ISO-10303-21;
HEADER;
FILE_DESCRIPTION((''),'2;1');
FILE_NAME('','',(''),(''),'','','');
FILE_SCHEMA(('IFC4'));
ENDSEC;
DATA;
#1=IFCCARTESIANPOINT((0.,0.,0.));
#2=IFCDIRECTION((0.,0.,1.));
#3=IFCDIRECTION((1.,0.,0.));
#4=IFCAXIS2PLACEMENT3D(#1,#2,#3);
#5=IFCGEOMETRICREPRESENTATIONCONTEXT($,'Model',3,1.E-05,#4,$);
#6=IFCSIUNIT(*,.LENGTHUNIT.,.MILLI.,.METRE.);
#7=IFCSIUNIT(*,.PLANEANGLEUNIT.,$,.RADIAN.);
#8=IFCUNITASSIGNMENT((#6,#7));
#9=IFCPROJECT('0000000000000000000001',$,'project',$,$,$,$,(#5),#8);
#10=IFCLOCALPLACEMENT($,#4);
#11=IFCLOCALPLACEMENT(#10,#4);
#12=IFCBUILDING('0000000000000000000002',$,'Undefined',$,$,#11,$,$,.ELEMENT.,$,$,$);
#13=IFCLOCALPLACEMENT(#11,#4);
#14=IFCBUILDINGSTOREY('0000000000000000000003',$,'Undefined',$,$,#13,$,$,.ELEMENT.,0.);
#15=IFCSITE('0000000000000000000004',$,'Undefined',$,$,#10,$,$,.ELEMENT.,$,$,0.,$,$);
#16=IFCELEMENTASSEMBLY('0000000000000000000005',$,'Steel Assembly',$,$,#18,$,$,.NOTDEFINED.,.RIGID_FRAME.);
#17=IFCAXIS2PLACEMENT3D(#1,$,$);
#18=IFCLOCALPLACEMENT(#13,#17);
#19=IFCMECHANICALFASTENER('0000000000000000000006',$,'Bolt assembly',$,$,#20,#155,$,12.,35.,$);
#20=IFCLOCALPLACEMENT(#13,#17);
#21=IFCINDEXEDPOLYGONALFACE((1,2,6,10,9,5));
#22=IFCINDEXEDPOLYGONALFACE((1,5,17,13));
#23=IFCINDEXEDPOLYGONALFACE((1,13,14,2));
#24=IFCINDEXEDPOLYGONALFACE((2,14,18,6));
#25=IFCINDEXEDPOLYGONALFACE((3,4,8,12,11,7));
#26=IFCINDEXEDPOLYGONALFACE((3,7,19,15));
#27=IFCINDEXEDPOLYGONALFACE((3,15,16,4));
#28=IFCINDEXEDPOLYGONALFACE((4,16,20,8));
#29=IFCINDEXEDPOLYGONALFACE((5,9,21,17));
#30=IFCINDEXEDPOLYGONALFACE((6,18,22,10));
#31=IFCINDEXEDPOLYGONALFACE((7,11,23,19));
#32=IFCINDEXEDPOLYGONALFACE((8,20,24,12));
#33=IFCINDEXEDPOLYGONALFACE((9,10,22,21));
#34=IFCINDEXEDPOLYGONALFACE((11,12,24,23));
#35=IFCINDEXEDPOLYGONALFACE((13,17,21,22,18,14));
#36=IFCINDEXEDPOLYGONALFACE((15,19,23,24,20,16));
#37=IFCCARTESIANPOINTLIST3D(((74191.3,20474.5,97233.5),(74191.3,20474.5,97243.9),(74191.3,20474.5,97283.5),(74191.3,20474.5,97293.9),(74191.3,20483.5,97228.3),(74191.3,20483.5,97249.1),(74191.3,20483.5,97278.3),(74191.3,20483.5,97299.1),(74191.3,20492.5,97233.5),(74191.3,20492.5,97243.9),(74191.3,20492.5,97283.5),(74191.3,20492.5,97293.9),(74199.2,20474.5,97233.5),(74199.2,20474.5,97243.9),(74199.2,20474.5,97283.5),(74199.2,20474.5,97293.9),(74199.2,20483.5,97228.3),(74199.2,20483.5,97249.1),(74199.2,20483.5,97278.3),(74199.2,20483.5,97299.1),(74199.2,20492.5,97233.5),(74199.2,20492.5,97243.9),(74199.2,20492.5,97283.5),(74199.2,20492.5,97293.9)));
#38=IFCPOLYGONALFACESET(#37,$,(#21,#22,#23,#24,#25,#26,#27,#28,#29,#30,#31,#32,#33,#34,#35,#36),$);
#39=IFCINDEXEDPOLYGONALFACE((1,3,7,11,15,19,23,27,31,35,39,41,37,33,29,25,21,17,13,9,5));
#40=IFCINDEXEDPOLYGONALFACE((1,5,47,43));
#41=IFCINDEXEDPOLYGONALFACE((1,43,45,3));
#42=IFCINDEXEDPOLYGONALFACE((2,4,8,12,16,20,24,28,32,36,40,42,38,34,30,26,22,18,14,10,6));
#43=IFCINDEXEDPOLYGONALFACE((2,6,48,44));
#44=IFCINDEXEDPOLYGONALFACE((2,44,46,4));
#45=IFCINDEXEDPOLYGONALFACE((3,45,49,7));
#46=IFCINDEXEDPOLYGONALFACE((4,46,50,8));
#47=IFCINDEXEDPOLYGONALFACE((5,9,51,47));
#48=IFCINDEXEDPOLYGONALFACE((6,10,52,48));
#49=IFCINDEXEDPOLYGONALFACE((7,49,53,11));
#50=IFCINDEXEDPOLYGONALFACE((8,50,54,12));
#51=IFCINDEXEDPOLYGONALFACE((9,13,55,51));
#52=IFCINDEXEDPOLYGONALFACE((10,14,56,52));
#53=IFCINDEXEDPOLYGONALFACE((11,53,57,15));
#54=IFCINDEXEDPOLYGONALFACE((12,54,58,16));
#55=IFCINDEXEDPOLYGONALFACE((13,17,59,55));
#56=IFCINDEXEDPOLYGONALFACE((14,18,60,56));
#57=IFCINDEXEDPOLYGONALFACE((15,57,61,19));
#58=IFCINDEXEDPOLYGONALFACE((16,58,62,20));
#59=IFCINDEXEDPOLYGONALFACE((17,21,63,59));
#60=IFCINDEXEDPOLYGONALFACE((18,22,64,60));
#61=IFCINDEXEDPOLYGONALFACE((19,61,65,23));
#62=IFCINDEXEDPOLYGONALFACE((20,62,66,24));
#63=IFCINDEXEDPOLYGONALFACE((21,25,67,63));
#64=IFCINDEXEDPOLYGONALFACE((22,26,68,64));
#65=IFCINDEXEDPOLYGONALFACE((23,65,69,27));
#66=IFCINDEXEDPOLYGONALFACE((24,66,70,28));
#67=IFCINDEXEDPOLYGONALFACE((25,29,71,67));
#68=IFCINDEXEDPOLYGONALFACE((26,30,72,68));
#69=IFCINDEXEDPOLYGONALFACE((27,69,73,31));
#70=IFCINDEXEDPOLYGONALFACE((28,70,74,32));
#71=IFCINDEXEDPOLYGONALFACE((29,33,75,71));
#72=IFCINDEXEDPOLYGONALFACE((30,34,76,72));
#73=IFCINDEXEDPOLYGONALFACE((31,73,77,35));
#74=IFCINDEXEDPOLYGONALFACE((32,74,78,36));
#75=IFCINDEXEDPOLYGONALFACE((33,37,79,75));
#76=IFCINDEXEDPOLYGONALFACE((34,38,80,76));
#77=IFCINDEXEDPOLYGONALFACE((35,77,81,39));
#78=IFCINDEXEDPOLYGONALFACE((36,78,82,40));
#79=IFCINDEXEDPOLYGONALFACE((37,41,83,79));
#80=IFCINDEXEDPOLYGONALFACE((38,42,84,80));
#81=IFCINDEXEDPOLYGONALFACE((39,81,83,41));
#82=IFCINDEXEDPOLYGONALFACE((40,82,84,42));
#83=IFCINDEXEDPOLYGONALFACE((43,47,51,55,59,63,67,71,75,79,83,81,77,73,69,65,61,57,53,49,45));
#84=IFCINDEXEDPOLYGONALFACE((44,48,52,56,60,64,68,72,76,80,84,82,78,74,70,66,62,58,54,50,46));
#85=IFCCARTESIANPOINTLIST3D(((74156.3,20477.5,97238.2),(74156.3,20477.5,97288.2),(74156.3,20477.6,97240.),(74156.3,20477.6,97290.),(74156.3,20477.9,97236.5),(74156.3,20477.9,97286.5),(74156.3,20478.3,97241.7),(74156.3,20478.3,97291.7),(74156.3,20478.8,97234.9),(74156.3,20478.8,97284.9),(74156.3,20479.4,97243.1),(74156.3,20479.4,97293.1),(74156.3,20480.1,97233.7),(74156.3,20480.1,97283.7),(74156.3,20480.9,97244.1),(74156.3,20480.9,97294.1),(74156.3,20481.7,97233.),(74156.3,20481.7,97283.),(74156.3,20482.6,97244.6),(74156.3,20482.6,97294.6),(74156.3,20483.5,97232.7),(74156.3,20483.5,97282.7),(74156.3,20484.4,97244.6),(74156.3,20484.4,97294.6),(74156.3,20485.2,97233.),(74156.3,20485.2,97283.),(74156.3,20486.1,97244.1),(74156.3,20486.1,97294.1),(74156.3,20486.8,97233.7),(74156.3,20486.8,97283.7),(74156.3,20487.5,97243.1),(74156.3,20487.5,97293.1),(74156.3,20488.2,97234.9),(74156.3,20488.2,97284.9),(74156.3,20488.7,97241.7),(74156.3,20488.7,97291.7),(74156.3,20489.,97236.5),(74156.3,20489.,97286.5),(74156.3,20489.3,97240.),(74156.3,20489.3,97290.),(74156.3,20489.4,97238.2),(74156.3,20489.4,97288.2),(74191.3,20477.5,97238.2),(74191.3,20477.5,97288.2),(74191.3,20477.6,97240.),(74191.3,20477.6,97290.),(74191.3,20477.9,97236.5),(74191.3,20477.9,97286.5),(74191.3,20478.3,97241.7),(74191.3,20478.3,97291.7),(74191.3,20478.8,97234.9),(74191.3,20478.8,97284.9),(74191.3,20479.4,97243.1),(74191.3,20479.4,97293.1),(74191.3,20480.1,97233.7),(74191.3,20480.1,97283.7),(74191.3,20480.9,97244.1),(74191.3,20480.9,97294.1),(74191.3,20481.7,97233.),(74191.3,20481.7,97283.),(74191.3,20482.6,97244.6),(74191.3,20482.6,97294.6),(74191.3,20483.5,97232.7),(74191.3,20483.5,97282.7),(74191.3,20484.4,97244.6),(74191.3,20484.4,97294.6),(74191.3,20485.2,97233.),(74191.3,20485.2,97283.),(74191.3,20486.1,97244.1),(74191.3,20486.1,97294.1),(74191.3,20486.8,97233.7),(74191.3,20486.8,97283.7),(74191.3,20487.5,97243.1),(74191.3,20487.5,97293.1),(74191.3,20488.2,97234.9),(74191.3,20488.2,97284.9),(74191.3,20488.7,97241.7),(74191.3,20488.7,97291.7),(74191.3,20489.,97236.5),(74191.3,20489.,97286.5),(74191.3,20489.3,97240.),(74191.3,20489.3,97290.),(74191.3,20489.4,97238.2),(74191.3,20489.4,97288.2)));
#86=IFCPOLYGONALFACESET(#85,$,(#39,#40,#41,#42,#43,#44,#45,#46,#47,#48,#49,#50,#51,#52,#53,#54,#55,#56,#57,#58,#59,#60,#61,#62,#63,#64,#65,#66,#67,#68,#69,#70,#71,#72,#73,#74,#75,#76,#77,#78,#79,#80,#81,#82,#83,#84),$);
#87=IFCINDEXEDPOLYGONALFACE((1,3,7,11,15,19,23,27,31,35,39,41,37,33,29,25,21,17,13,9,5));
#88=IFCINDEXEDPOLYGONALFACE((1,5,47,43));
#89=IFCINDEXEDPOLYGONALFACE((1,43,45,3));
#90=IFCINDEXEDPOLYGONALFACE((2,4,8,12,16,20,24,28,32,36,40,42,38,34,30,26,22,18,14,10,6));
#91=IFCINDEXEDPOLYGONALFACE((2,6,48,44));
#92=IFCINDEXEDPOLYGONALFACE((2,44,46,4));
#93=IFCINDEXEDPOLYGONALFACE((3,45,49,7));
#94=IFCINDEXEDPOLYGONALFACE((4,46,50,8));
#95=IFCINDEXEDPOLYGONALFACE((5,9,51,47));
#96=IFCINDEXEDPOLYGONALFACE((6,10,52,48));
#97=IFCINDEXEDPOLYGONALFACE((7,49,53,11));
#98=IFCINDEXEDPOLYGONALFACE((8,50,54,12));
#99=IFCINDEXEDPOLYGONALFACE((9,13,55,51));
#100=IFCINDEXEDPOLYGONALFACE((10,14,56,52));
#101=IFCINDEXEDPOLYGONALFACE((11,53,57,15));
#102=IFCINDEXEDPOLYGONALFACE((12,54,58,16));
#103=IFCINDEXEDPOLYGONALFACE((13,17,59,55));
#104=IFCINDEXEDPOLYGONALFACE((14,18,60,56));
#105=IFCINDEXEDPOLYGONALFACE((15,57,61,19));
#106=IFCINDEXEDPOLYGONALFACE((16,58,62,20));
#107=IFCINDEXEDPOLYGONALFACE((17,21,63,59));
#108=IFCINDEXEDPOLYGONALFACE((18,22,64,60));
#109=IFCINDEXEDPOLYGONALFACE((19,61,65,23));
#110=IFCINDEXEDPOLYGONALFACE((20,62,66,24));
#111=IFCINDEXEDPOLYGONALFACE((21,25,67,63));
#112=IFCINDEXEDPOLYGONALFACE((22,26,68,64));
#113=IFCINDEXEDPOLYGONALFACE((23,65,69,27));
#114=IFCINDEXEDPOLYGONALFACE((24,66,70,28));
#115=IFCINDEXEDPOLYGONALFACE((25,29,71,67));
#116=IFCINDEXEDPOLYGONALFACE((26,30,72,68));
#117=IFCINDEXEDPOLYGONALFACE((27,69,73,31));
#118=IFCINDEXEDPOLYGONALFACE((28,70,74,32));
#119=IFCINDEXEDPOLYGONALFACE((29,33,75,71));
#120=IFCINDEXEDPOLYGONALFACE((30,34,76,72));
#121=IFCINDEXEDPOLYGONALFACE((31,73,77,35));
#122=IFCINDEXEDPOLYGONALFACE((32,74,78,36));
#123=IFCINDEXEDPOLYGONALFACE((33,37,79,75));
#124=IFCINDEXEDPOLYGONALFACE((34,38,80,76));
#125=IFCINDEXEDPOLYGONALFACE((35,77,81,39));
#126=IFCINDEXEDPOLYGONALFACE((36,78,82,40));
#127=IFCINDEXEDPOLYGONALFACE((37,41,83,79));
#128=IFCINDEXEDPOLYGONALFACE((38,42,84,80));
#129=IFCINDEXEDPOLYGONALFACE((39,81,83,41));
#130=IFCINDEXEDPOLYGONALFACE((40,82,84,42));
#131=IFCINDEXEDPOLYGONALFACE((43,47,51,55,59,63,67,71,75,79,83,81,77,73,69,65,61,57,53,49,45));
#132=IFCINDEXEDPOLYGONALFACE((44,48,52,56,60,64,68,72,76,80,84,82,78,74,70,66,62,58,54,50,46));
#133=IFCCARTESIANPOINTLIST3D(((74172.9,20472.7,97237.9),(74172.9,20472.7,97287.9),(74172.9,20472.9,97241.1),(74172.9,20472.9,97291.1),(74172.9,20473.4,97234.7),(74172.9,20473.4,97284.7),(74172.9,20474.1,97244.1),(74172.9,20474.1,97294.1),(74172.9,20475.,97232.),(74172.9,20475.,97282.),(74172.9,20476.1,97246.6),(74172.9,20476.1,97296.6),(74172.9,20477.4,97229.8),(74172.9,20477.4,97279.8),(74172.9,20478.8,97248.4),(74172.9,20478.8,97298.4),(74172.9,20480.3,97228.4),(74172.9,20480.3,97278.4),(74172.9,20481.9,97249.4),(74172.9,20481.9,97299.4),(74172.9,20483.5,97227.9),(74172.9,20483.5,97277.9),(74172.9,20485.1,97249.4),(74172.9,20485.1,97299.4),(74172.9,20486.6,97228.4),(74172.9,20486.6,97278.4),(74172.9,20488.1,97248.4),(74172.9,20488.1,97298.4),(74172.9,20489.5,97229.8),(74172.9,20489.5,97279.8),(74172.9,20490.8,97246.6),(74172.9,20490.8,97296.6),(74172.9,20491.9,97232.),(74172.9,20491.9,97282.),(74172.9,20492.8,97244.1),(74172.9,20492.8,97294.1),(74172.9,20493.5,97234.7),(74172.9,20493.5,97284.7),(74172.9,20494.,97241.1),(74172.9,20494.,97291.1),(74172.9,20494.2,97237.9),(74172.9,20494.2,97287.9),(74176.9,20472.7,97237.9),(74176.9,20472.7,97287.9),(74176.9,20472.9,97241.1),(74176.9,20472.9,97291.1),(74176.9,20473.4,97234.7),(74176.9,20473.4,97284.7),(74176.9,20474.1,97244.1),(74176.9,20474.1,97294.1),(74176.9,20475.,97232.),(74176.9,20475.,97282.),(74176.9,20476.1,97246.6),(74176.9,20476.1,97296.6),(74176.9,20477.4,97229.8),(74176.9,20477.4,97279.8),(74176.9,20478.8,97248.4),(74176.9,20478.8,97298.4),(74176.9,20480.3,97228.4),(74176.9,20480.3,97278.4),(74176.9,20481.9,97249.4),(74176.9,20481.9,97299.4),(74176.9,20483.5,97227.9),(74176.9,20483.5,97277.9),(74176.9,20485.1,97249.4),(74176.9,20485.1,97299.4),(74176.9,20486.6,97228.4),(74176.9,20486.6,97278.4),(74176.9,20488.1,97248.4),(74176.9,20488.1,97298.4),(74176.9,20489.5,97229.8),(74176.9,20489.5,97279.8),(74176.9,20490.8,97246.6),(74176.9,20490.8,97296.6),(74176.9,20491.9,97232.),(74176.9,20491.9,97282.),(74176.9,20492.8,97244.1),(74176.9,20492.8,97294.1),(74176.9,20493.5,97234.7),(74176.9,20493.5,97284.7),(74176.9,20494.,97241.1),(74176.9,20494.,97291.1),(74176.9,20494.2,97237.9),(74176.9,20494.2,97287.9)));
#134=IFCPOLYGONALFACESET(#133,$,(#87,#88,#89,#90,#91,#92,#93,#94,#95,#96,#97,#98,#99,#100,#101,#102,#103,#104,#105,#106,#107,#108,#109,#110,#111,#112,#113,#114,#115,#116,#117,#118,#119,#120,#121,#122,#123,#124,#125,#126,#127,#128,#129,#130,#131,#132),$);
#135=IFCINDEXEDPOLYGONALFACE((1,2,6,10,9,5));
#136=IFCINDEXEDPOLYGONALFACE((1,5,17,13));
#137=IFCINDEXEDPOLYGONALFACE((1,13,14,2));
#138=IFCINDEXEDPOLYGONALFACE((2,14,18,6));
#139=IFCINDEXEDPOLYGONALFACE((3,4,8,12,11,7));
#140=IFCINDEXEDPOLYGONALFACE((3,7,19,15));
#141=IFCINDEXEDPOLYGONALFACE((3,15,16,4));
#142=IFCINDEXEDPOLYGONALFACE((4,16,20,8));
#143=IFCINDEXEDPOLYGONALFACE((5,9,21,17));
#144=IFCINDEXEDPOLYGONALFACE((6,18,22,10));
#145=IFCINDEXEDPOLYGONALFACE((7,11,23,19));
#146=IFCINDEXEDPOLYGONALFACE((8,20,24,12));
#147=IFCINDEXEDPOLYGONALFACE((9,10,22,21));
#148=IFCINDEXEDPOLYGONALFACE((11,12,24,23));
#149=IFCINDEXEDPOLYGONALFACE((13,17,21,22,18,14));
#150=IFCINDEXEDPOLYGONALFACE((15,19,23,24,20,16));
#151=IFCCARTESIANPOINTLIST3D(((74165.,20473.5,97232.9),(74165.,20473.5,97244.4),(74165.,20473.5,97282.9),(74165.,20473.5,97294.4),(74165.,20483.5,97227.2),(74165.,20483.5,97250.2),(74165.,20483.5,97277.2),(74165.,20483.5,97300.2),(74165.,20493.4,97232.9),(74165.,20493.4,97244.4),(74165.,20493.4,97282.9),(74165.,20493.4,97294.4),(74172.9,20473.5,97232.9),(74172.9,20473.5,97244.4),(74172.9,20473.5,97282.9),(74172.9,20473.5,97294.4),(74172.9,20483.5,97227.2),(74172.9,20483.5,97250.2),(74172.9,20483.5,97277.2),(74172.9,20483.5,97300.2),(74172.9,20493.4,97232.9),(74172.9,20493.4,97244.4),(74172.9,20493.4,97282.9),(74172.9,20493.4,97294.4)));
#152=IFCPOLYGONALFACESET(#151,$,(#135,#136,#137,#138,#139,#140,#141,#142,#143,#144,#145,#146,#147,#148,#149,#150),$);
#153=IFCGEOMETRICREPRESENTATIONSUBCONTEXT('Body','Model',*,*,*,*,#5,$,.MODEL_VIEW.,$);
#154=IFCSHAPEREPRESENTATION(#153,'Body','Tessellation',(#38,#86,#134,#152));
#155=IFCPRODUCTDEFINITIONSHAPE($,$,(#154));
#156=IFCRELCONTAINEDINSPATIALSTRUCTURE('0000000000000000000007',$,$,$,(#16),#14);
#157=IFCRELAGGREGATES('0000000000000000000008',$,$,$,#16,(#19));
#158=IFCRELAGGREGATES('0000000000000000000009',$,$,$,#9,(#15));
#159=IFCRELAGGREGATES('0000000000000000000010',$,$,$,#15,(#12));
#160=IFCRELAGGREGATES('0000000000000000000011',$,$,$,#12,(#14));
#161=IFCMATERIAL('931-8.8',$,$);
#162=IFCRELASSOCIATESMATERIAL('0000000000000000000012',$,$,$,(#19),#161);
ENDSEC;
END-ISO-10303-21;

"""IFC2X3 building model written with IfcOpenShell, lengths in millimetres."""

from ifc_helpers import new_model, si_unit, frame, origin_with_axes, origin_2d_with_axis, place, context, subcontext, project, spatial, polyline, circle, outline, extrude, source, transform, mapped, material, element, aggregate, save


model = new_model("IFC2X3")

# Units and contexts
model_context = context("Model", 3, precision=1e-05, world=origin_with_axes())
body_context = subcontext(model_context, "Body", "Model", "MODEL_VIEW")
ifc_project = project(units=[si_unit("LENGTHUNIT", "METRE", prefix="MILLI"), si_unit("PLANEANGLEUNIT", "RADIAN")], contexts=[model_context])

# Site, building, storey
site_placement = place(None, origin_with_axes())
site = spatial("IfcSite", under=ifc_project, at=site_placement, Name="Undefined", CompositionType="ELEMENT", RefElevation=0.0)
building_placement = place(site_placement, origin_with_axes())
building = spatial("IfcBuilding", under=site, at=building_placement, Name="Undefined", CompositionType="ELEMENT")
storey_placement = place(building_placement, origin_with_axes())
storey = spatial("IfcBuildingStorey", under=building, at=storey_placement, Name="Undefined", CompositionType="ELEMENT", Elevation=0.0)

# Shared definitions
ifc_material_1 = material(Name="931-8.8")

# Element assembly, mechanical fastener
assembly_1_placement = place(storey_placement, origin_with_axes())
assembly_1 = element("IfcElementAssembly", 1, at=assembly_1_placement, inside=storey, Name="Steel Assembly", AssemblyPlace="NOTDEFINED", PredefinedType="RIGID_FRAME")
shared_shape_1 = source(origin_with_axes(), body_context, "Body", "SweptSolid", [
    extrude(outline(polyline([(10.4, 0.0), (5.2, 9.0), (-5.2, 9.0), (-10.4, 0.0), (-5.2, -9.0), (5.2, -9.0), (10.4, 0.0)])), frame((0.0, -22.3, 0.0), z_axis=(0.0, 1.0, 0.0), x_axis=(1.0, 0.0, 0.0)), (0.0, 0.0, 1.0), 7.9),
    extrude(circle(Radius=6.0, at=origin_2d_with_axis()), frame((0.0, -14.4, 0.0), z_axis=(0.0, 1.0, 0.0), x_axis=(1.0, 0.0, 0.0)), (0.0, 0.0, 1.0), 35.0),
    extrude(circle(Radius=10.8, at=origin_2d_with_axis()), frame((0.0, 0.0, 0.0), z_axis=(0.0, 1.0, 0.0), x_axis=(1.0, 0.0, 0.0)), (0.0, 0.0, 1.0), 4.0),
    extrude(outline(polyline([(11.5, 0.0), (5.8, 10.0), (-5.8, 10.0), (-11.5, 0.0), (-5.8, -10.0), (5.8, -10.0), (11.5, 0.0)])), frame((0.0, 4.0, 0.0), z_axis=(0.0, 1.0, 0.0), x_axis=(1.0, 0.0, 0.0)), (0.0, 0.0, 1.0), 7.9),
])
mechanical_fastener_1_placement = place(assembly_1_placement, frame((74176.9, 20483.5, 97288.7), z_axis=(0.0, 1.0, 0.0), x_axis=(0.0, 0.0, -1.0)))
mechanical_fastener_1 = element("IfcMechanicalFastener", 2, at=mechanical_fastener_1_placement, material=ifc_material_1, Name="Bolt assembly", NominalDiameter=12.0, NominalLength=35.0, context=body_context, shape_type="MappedRepresentation", body=[
    mapped(shared_shape_1, transform((0.0, 0.0, 0.0))),
    mapped(shared_shape_1, transform((50.0, 0.0, 0.0))),
])

aggregate(assembly_1, [mechanical_fastener_1])

save(model, "model.ifc")
